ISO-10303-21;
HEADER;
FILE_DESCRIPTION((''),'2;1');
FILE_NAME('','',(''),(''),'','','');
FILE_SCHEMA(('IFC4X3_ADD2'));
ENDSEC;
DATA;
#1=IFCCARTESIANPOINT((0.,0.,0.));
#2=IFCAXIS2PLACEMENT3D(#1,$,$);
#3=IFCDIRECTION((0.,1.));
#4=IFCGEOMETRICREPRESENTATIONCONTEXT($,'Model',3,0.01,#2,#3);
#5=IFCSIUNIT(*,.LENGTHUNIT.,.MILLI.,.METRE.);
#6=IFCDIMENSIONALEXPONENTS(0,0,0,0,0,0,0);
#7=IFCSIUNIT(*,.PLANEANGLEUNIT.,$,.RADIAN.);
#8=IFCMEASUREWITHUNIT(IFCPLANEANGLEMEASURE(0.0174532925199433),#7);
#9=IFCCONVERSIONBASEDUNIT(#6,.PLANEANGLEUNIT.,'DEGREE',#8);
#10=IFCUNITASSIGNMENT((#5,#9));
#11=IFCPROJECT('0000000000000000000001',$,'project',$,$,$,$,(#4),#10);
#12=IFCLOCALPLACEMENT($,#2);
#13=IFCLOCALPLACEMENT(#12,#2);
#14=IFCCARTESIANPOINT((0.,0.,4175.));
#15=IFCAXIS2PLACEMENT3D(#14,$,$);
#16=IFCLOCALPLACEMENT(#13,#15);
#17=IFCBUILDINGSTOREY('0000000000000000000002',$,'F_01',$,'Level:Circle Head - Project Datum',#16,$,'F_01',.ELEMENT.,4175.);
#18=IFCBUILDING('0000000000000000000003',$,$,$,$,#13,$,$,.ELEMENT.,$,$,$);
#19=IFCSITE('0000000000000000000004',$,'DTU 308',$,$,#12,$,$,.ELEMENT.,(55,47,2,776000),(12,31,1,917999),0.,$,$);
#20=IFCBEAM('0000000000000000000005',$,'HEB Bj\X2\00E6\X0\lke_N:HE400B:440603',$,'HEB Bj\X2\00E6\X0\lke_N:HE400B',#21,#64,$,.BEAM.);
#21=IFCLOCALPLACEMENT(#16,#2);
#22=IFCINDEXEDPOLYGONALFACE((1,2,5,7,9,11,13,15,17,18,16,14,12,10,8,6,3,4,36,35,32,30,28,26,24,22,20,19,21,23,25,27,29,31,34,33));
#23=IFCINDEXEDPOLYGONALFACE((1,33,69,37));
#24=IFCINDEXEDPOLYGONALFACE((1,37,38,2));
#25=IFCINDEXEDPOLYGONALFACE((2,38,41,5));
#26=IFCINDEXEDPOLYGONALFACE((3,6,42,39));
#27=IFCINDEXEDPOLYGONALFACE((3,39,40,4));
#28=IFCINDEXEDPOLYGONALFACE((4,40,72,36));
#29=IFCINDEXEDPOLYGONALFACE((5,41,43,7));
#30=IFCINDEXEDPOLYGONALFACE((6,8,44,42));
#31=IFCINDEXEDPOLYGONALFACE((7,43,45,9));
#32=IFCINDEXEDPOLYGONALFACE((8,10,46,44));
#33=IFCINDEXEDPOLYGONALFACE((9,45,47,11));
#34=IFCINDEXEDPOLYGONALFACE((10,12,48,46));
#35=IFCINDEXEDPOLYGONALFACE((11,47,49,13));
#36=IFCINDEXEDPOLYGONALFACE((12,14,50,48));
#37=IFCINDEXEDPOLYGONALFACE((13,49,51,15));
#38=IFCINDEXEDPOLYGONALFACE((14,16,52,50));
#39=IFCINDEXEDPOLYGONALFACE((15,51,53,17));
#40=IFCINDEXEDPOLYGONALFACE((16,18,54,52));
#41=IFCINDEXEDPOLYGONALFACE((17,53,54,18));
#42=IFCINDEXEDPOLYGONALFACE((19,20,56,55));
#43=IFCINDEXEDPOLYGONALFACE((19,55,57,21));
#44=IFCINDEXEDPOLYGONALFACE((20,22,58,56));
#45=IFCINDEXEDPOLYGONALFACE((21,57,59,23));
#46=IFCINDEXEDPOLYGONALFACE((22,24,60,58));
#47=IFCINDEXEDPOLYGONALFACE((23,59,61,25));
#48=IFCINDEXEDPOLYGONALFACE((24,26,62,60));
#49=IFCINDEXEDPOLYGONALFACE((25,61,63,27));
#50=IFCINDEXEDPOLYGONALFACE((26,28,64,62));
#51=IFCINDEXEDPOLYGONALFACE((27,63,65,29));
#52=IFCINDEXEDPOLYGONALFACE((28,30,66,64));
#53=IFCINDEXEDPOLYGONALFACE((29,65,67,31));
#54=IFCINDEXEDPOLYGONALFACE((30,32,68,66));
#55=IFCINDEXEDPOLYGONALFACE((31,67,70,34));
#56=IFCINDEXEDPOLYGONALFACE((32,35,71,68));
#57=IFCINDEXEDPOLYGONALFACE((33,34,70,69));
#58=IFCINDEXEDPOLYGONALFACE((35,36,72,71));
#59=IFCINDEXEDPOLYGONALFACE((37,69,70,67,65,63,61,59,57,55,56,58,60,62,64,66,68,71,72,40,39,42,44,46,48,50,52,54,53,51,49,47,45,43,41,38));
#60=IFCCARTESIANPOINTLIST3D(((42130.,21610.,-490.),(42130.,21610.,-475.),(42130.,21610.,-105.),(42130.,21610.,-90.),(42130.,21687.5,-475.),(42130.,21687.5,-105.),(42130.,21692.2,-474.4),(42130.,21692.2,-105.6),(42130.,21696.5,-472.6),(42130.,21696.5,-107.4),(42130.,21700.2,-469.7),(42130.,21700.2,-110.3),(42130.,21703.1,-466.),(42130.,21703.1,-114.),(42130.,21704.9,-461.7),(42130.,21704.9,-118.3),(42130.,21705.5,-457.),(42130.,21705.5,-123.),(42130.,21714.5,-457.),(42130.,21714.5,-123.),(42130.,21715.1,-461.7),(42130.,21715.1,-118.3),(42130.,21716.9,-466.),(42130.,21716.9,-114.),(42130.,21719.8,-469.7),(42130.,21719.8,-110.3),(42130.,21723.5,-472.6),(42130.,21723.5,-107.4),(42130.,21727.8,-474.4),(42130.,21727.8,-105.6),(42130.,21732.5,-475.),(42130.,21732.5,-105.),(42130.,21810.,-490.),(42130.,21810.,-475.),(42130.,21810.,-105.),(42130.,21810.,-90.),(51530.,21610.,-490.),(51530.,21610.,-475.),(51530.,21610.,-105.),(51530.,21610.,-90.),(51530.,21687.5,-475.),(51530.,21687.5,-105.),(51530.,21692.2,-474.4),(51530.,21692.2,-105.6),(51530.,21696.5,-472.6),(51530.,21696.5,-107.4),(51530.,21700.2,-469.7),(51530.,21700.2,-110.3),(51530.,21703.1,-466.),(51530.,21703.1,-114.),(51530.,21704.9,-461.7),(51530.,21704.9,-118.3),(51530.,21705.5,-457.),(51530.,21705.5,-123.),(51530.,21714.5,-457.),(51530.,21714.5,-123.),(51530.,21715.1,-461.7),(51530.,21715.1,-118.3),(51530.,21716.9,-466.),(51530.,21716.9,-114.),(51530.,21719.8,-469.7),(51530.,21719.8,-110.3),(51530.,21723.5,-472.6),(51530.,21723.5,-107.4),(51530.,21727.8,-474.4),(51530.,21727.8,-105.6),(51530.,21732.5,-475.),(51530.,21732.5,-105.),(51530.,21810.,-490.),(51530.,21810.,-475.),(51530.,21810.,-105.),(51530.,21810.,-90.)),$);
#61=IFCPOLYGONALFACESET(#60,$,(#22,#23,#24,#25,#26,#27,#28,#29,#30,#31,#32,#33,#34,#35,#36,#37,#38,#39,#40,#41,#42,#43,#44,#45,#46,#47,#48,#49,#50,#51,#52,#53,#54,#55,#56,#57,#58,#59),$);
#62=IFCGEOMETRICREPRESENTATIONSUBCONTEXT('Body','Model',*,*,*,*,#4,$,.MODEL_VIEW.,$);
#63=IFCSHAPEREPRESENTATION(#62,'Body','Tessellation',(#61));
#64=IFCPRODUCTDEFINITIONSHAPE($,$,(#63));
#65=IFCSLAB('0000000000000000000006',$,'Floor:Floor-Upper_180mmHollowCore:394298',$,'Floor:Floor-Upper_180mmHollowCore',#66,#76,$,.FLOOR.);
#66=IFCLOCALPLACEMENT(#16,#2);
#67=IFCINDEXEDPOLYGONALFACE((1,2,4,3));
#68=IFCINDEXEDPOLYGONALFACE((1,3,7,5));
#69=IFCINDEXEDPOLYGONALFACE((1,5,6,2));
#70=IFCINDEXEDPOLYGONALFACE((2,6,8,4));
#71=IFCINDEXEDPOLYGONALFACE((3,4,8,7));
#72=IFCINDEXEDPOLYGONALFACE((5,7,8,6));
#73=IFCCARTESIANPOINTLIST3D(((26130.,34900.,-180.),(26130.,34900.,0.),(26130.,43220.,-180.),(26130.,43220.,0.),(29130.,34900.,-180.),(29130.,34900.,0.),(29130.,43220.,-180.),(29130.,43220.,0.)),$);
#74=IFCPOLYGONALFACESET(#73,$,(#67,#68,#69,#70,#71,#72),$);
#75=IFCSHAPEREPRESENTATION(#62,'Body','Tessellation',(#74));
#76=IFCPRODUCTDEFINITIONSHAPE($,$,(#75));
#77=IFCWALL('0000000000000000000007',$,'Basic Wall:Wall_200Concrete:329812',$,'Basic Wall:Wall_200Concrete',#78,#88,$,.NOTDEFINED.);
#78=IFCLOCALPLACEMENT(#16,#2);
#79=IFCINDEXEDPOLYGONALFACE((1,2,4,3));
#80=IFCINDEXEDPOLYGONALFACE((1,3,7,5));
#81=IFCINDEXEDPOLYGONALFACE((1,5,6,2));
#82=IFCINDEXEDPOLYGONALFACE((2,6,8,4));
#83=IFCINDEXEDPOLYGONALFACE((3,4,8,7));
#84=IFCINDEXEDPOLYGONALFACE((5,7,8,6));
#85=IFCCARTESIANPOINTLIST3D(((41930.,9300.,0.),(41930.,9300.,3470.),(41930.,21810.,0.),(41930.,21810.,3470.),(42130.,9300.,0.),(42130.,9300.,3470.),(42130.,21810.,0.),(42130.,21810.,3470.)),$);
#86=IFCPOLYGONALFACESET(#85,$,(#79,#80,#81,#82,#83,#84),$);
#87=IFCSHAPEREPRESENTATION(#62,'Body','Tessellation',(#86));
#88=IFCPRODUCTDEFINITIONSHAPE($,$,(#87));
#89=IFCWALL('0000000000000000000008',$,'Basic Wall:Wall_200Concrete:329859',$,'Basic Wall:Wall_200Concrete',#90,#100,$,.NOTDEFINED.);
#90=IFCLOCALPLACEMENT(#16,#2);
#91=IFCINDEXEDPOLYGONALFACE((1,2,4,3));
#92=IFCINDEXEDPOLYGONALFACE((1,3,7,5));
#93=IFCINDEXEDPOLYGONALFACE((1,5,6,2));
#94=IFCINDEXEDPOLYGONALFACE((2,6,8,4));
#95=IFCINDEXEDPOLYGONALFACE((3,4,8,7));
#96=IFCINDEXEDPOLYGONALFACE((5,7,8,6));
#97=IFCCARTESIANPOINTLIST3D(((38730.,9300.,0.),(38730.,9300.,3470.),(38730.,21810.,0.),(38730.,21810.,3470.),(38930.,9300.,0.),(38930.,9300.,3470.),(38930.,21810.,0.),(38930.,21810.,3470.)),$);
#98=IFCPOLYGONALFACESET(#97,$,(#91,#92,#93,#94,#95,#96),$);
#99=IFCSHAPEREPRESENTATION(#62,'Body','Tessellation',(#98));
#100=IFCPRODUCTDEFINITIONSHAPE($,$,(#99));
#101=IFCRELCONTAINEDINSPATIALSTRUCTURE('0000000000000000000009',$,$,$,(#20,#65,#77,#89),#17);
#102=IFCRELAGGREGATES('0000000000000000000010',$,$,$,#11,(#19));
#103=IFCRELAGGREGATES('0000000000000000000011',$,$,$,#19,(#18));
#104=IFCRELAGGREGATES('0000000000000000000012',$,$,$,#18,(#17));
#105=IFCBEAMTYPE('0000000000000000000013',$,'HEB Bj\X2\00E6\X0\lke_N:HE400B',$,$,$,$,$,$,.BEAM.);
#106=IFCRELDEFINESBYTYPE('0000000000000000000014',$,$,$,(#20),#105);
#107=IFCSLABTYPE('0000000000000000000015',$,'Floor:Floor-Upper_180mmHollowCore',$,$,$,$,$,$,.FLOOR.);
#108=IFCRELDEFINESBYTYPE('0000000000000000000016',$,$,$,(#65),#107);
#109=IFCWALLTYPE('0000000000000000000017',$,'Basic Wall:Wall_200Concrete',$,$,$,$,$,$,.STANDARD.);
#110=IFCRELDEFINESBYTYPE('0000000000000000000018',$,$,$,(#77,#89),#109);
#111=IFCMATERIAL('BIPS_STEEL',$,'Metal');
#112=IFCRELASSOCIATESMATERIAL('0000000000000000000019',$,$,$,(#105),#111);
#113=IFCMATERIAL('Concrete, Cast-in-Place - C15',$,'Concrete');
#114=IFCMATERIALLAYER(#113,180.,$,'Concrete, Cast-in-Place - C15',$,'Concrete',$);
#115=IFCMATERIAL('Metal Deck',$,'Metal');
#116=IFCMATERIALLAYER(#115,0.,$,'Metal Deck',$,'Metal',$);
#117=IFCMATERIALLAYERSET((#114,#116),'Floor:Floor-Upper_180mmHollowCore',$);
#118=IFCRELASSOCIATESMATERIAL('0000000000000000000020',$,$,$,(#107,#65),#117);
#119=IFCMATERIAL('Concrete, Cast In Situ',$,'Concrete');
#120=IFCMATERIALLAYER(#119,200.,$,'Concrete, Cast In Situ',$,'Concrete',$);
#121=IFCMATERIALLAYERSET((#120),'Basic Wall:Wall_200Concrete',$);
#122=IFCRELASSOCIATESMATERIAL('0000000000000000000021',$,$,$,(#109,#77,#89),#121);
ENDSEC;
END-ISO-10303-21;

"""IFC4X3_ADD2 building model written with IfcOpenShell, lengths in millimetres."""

from ifc_helpers import new_model, entity, si_unit, converted_unit, direction, frame, frame_2d, origin, place, context, subcontext, project, spatial, polyline, circle_curve, parameter, trimmed, segment, composite_curve, rectangle, outline, extrude, clip, bounded_halfspace, source, transform, mapped, material, layer, layer_set, layer_usage, material_profile, profile_set, type_object, element, save


model = new_model("IFC4X3_ADD2")

# Units and contexts
model_context = context("Model", 3, precision=0.01, world=origin(), true_north=direction((0.0, 1.0)))
body_context = subcontext(model_context, "Body", "Model", "MODEL_VIEW")
ifc_project = project(units=[si_unit("LENGTHUNIT", "METRE", prefix="MILLI"), converted_unit("PLANEANGLEUNIT", "DEGREE", entity("IfcPlaneAngleMeasure", 0.0174532925199433), si_unit("PLANEANGLEUNIT", "RADIAN"), dimensions=[0, 0, 0, 0, 0, 0, 0])], contexts=[model_context])

# Site, building, storey
site_placement = place(None, origin())
site = spatial("IfcSite", under=ifc_project, at=site_placement, Name="DTU 308", CompositionType="ELEMENT", RefLatitude=(55, 47, 2, 776000), RefLongitude=(12, 31, 1, 917999), RefElevation=0.0)
building_placement = place(site_placement, origin())
building = spatial("IfcBuilding", under=site, at=building_placement, CompositionType="ELEMENT")
storey_placement = place(building_placement, frame((0.0, 0.0, 4175.0)))
storey = spatial("IfcBuildingStorey", under=building, at=storey_placement, Name="F_01", ObjectType="Level:Circle Head - Project Datum", LongName="F_01", CompositionType="ELEMENT", Elevation=4175.0)

# Shared definitions
ifc_material_1 = material(Name="BIPS_STEEL", Category="Metal")

# Beam
ifc_material_profile_1 = material_profile(ifc_material_1, outline(composite_curve([segment(polyline([(-100.0, -185.0), (-100.0, -200.0)]), True, "CONTINUOUS"), segment(polyline([(-100.0, -200.0), (100.0, -200.0)]), True, "CONTINUOUS"), segment(polyline([(100.0, -200.0), (100.0, -185.0)]), True, "CONTINUOUS"), segment(polyline([(100.0, -185.0), (22.5, -185.0)]), True, "CONTINUOUS"), segment(trimmed(circle_curve(frame_2d((22.5, -167.0), x_axis=(1.0, 0.0)), 18.0), [parameter(180.0)], [parameter(270.0)], True, "PARAMETER"), False, "CONTINUOUS"), segment(polyline([(4.5, -167.0), (4.5, 167.0)]), True, "CONTINUOUS"), segment(trimmed(circle_curve(frame_2d((22.5, 167.0), x_axis=(1.0, 0.0)), 18.0), [parameter(90.0)], [parameter(180.0)], True, "PARAMETER"), False, "CONTINUOUS"), segment(polyline([(22.5, 185.0), (100.0, 185.0)]), True, "CONTINUOUS"), segment(polyline([(100.0, 185.0), (100.0, 200.0)]), True, "CONTINUOUS"), segment(polyline([(100.0, 200.0), (-100.0, 200.0)]), True, "CONTINUOUS"), segment(polyline([(-100.0, 200.0), (-100.0, 185.0)]), True, "CONTINUOUS"), segment(polyline([(-100.0, 185.0), (-22.5, 185.0)]), True, "CONTINUOUS"), segment(trimmed(circle_curve(frame_2d((-22.5, 167.0), x_axis=(1.0, 0.0)), 18.0), [parameter(360.0)], [parameter(90.0)], True, "PARAMETER"), False, "CONTINUOUS"), segment(polyline([(-4.5, 167.0), (-4.5, -167.0)]), True, "CONTINUOUS"), segment(trimmed(circle_curve(frame_2d((-22.5, -167.0), x_axis=(1.0, 0.0)), 18.0), [parameter(270.0)], [parameter(360.0)], True, "PARAMETER"), False, "CONTINUOUS"), segment(polyline([(-22.5, -185.0), (-100.0, -185.0)]), True, "CONTINUOUS")], self_intersect=False)), Name="HE400B")
ifc_profile_set_1 = profile_set([ifc_material_profile_1], Name="HE400B")
beam_type_1 = type_object("IfcBeamType", Name="HEB Bjælke_N:HE400B", PredefinedType="BEAM", material=ifc_profile_set_1)
shared_shape_1 = source(origin(), body_context, "Body", "SweptSolid", [
    extrude(outline(composite_curve([segment(polyline([(-100.0, -185.0), (-100.0, -200.0)]), True, "CONTINUOUS"), segment(polyline([(-100.0, -200.0), (100.0, -200.0)]), True, "CONTINUOUS"), segment(polyline([(100.0, -200.0), (100.0, -185.0)]), True, "CONTINUOUS"), segment(polyline([(100.0, -185.0), (22.5, -185.0)]), True, "CONTINUOUS"), segment(trimmed(circle_curve(frame_2d((22.5, -167.0), x_axis=(1.0, 0.0)), 18.0), [parameter(180.0)], [parameter(270.0)], True, "PARAMETER"), False, "CONTINUOUS"), segment(polyline([(4.5, -167.0), (4.5, 167.0)]), True, "CONTINUOUS"), segment(trimmed(circle_curve(frame_2d((22.5, 167.0), x_axis=(1.0, 0.0)), 18.0), [parameter(90.0)], [parameter(180.0)], True, "PARAMETER"), False, "CONTINUOUS"), segment(polyline([(22.5, 185.0), (100.0, 185.0)]), True, "CONTINUOUS"), segment(polyline([(100.0, 185.0), (100.0, 200.0)]), True, "CONTINUOUS"), segment(polyline([(100.0, 200.0), (-100.0, 200.0)]), True, "CONTINUOUS"), segment(polyline([(-100.0, 200.0), (-100.0, 185.0)]), True, "CONTINUOUS"), segment(polyline([(-100.0, 185.0), (-22.5, 185.0)]), True, "CONTINUOUS"), segment(trimmed(circle_curve(frame_2d((-22.5, 167.0), x_axis=(1.0, 0.0)), 18.0), [parameter(360.0)], [parameter(90.0)], True, "PARAMETER"), False, "CONTINUOUS"), segment(polyline([(-4.5, 167.0), (-4.5, -167.0)]), True, "CONTINUOUS"), segment(trimmed(circle_curve(frame_2d((-22.5, -167.0), x_axis=(1.0, 0.0)), 18.0), [parameter(270.0)], [parameter(360.0)], True, "PARAMETER"), False, "CONTINUOUS"), segment(polyline([(-22.5, -185.0), (-100.0, -185.0)]), True, "CONTINUOUS")], self_intersect=False)), frame((-4700.0, 0.0, 0.0), z_axis=(-1.0, 0.0, 0.0), x_axis=(0.0, -1.0, 0.0)), (0.0, 0.0, -1.0), 9400.0),
])
beam_1_placement = place(storey_placement, frame((46830.0, 21710.0, -290.0)))
element("IfcBeam", 1, at=beam_1_placement, inside=storey, type_object=beam_type_1, Name="HEB Bjælke_N:HE400B:440603", ObjectType="HEB Bjælke_N:HE400B", PredefinedType="BEAM", context=body_context, shape_type="MappedRepresentation", body=[
    mapped(shared_shape_1, transform((0.0, 0.0, 0.0), scale=1.0)),
])

# Slab
ifc_material_2 = material(Name="Concrete, Cast-in-Place - C15", Category="Concrete")
ifc_layer_1 = layer(ifc_material_2, 180.0, Name="Concrete, Cast-in-Place - C15", Category="Concrete")
ifc_material_3 = material(Name="Metal Deck", Category="Metal")
ifc_layer_2 = layer(ifc_material_3, 0.0, Name="Metal Deck", Category="Metal")
ifc_layer_set_1 = layer_set([ifc_layer_1, ifc_layer_2], Name="Floor:Floor-Upper_180mmHollowCore")
ifc_layer_usage = layer_usage(ifc_layer_set_1, "AXIS3", "POSITIVE", 0.0)
slab_type = type_object("IfcSlabType", Name="Floor:Floor-Upper_180mmHollowCore", PredefinedType="FLOOR", material=ifc_layer_set_1)
slab_1_placement = place(storey_placement, frame((26130.0, 34900.0, -180.0)))
element("IfcSlab", 2, at=slab_1_placement, inside=storey, type_object=slab_type, material=ifc_layer_usage, Name="Floor:Floor-Upper_180mmHollowCore:394298", ObjectType="Floor:Floor-Upper_180mmHollowCore", PredefinedType="FLOOR", context=body_context, shape_type="SweptSolid", body=[
    extrude(rectangle(XDim=8320.0, YDim=3000.0, at=frame_2d((4800.0, 0.0), x_axis=(0.0, -1.0))), frame((6300.0, 4160.0, 180.0), z_axis=(0.0, 0.0, -1.0), x_axis=(-1.0, 0.0, 0.0)), (0.0, 0.0, 1.0), 180.0),
])

# Walls
ifc_material_4 = material(Name="Concrete, Cast In Situ", Category="Concrete")
ifc_layer_3 = layer(ifc_material_4, 200.0, Name="Concrete, Cast In Situ", Category="Concrete")
ifc_layer_set_2 = layer_set([ifc_layer_3], Name="Basic Wall:Wall_200Concrete")
wall_type = type_object("IfcWallType", Name="Basic Wall:Wall_200Concrete", PredefinedType="STANDARD", material=ifc_layer_set_2)
wall_1_placement = place(storey_placement, frame((42030.0, 21810.0, 0.0), z_axis=(0.0, 0.0, 1.0), x_axis=(0.0, -1.0, 0.0)))
element("IfcWall", 3, at=wall_1_placement, inside=storey, type_object=wall_type, material=ifc_layer_set_2, Name="Basic Wall:Wall_200Concrete:329812", ObjectType="Basic Wall:Wall_200Concrete", PredefinedType="NOTDEFINED", context=body_context, shape_type="Clipping", body=[
    clip(extrude(rectangle(XDim=12510.0, YDim=200.0, at=frame_2d((6255.0, 0.0), x_axis=(-1.0, 0.0))), origin(), (0.0, 0.0, 1.0), 3470.0), bounded_halfspace(frame((12510.0, -100.0, 3470.0), z_axis=(-1.0, 0.0, 0.0), x_axis=(0.0, -1.0, 0.0)), True, frame((12510.0, -100.0, 3470.0), z_axis=(-1.0, 0.0, 0.0), x_axis=(0.0, -1.0, 0.0)), polyline([(0.0, 0.0), (-200.0, 0.0), (-200.0, -3470.0), (0.0, -3470.0), (0.0, -300.0), (0.0, 0.0)]))),
])
wall_2_placement = place(storey_placement, frame((38830.0, 21810.0, 0.0), z_axis=(0.0, 0.0, 1.0), x_axis=(0.0, -1.0, 0.0)))
element("IfcWall", 4, at=wall_2_placement, inside=storey, type_object=wall_type, material=ifc_layer_set_2, Name="Basic Wall:Wall_200Concrete:329859", ObjectType="Basic Wall:Wall_200Concrete", PredefinedType="NOTDEFINED", context=body_context, shape_type="SweptSolid", body=[
    extrude(rectangle(XDim=12510.0, YDim=200.0, at=frame_2d((6255.0, 0.0), x_axis=(-1.0, 0.0))), origin(), (0.0, 0.0, 1.0), 3470.0),
])

save(model, "model.ifc")
